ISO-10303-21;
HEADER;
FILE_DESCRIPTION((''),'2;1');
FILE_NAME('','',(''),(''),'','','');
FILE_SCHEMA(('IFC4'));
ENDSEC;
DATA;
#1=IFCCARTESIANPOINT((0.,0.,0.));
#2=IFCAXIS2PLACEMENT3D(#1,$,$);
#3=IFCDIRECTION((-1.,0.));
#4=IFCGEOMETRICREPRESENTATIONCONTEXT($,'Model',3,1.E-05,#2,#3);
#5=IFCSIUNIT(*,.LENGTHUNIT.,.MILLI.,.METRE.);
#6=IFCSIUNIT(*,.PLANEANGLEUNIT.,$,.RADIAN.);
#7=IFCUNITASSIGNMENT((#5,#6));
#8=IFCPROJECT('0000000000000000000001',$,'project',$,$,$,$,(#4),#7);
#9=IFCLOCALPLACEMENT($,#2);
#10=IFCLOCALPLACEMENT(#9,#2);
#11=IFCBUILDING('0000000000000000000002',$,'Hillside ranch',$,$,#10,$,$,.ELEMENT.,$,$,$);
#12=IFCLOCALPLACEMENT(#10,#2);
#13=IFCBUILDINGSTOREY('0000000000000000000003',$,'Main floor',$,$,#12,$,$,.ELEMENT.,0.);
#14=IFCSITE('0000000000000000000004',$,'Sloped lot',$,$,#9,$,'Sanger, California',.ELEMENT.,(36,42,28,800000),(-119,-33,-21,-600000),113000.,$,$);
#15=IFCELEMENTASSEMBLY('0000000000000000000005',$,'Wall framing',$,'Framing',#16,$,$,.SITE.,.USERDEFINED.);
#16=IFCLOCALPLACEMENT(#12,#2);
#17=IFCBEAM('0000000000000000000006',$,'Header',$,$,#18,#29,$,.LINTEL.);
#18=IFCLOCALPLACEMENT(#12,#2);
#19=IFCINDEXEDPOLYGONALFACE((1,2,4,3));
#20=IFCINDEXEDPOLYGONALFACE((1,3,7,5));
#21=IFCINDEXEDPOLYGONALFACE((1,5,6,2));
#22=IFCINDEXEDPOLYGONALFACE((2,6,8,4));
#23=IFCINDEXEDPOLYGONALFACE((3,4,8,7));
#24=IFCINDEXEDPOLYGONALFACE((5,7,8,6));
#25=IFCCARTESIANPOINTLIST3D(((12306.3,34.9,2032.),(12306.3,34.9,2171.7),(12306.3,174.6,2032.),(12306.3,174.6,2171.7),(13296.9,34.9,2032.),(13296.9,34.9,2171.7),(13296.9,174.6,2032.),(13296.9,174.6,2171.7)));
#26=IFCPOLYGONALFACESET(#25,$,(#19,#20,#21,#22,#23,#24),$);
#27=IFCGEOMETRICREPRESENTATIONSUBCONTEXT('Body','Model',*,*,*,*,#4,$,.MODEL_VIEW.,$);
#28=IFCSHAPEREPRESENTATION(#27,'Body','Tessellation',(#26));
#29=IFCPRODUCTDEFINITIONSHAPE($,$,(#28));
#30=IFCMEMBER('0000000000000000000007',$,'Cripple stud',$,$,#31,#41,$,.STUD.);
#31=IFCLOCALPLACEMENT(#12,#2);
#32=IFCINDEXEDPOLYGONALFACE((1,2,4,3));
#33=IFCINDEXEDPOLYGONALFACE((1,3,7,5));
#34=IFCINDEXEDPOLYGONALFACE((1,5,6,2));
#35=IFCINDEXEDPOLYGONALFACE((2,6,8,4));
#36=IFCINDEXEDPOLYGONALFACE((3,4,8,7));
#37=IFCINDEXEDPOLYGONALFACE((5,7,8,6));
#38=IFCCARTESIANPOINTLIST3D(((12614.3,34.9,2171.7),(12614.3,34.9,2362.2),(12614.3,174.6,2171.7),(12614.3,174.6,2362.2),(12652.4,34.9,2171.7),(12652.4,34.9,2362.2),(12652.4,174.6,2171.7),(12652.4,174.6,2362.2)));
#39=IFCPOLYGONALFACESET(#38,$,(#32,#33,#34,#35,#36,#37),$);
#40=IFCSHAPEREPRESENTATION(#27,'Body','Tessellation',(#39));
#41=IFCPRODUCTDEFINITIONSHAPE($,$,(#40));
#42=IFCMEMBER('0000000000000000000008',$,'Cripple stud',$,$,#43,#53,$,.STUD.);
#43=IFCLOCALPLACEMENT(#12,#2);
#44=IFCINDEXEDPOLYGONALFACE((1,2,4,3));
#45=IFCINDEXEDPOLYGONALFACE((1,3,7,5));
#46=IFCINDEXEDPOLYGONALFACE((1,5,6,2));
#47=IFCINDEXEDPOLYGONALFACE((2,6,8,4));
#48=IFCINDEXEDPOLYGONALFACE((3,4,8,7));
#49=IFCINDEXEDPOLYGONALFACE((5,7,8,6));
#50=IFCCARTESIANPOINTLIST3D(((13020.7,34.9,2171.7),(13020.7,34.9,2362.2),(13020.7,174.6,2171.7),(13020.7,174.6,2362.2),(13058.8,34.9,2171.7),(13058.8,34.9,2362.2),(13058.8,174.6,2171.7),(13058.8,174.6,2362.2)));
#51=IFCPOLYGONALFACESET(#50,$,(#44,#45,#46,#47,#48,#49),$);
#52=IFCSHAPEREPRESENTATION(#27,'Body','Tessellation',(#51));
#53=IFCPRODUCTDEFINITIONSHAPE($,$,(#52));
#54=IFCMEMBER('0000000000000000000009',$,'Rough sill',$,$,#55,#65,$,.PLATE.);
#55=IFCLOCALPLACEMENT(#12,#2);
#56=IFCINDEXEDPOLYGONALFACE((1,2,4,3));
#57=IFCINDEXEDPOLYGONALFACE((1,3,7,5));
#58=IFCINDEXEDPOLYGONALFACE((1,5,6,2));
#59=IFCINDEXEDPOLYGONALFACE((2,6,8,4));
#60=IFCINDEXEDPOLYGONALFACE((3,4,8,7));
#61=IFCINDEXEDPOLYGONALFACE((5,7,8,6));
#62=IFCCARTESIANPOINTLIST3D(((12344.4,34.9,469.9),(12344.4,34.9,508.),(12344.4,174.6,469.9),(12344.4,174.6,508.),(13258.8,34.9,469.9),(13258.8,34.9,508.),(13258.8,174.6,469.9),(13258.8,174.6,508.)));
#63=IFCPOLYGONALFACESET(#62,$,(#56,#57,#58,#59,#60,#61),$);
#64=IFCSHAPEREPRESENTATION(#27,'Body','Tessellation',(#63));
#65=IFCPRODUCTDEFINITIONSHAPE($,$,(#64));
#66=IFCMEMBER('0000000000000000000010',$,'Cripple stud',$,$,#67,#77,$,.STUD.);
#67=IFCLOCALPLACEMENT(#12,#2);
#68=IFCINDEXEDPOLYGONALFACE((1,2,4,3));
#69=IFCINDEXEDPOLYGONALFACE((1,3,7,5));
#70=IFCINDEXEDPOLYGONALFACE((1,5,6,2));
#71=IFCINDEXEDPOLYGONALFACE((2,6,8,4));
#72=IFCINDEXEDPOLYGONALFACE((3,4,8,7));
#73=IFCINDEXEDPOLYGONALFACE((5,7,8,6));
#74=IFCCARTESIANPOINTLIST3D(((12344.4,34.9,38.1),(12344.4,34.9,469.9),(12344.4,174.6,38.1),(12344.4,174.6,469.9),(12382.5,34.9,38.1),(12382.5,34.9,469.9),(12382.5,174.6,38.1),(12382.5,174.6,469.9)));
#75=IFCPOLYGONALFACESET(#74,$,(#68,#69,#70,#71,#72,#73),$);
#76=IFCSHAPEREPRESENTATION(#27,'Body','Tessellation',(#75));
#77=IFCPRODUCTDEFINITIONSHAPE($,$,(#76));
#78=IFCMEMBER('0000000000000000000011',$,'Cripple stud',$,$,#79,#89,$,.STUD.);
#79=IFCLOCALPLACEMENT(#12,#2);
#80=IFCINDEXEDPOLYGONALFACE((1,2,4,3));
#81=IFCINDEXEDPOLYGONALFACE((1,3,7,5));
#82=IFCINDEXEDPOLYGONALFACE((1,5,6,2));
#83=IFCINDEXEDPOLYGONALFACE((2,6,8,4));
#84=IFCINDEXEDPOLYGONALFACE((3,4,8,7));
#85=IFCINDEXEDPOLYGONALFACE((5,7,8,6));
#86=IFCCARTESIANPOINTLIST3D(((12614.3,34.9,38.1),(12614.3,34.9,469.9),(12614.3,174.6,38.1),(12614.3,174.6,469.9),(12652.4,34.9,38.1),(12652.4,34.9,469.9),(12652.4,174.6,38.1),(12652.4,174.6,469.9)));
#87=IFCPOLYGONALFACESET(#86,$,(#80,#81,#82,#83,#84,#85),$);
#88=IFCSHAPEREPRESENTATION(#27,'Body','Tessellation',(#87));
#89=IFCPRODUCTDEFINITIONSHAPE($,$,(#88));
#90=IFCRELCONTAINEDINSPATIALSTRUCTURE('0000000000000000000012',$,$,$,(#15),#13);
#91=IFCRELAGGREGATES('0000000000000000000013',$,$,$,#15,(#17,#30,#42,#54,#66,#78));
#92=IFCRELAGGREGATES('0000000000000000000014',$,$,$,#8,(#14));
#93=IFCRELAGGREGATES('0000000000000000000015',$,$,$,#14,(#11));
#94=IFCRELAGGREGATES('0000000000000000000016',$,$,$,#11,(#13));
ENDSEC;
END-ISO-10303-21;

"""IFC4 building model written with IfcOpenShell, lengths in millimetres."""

from ifc_helpers import new_model, si_unit, direction, frame, origin, origin_with_axes, place, context, subcontext, project, spatial, polyline, outline, extrude, element, aggregate, save


model = new_model("IFC4")

# Units and contexts
model_context = context("Model", 3, precision=1e-05, world=origin(), true_north=direction((-1.0, 0.0)))
body_context = subcontext(model_context, "Body", "Model", "MODEL_VIEW")
ifc_project = project(units=[si_unit("LENGTHUNIT", "METRE", prefix="MILLI"), si_unit("PLANEANGLEUNIT", "RADIAN")], contexts=[model_context])

# Site, building, storey
site_placement = place(None, origin())
site = spatial("IfcSite", under=ifc_project, at=site_placement, Name="Sloped lot", LongName="Sanger, California", CompositionType="ELEMENT", RefLatitude=(36, 42, 28, 800000), RefLongitude=(-119, -33, -21, -600000), RefElevation=113000.0)
building_placement = place(site_placement, origin())
building = spatial("IfcBuilding", under=site, at=building_placement, Name="Hillside ranch", CompositionType="ELEMENT")
storey_placement = place(building_placement, origin())
storey = spatial("IfcBuildingStorey", under=building, at=storey_placement, Name="Main floor", CompositionType="ELEMENT", Elevation=0.0)

# Element assembly, beam, members
assembly_placement = place(storey_placement, origin_with_axes())
assembly = element("IfcElementAssembly", 1, at=assembly_placement, inside=storey, Name="Wall framing", ObjectType="Framing", AssemblyPlace="SITE", PredefinedType="USERDEFINED")
beam_1_placement = place(storey_placement, origin_with_axes())
beam_1 = element("IfcBeam", 2, at=beam_1_placement, Name="Header", PredefinedType="LINTEL", context=body_context, shape_type="SweptSolid", body=[
    extrude(outline(polyline([(0.0, 0.0), (990.6, 0.0), (990.6, 139.7), (0.0, 139.7), (0.0, 0.0)])), frame((12306.3, 34.9, 2032.0), z_axis=(0.0, 0.0, 1.0), x_axis=(1.0, 0.0, 0.0)), (0.0, 0.0, 1.0), 139.7),
])
member_1_placement = place(storey_placement, origin_with_axes())
member_1 = element("IfcMember", 3, at=member_1_placement, Name="Cripple stud", PredefinedType="STUD", context=body_context, shape_type="SweptSolid", body=[
    extrude(outline(polyline([(0.0, 0.0), (38.1, 0.0), (38.1, 139.7), (0.0, 139.7), (0.0, 0.0)])), frame((12614.3, 34.9, 2171.7), z_axis=(0.0, 0.0, 1.0), x_axis=(1.0, 0.0, 0.0)), (0.0, 0.0, 1.0), 190.5),
])
member_2_placement = place(storey_placement, origin_with_axes())
member_2 = element("IfcMember", 4, at=member_2_placement, Name="Cripple stud", PredefinedType="STUD", context=body_context, shape_type="SweptSolid", body=[
    extrude(outline(polyline([(0.0, 0.0), (38.1, 0.0), (38.1, 139.7), (0.0, 139.7), (0.0, 0.0)])), frame((13020.7, 34.9, 2171.7), z_axis=(0.0, 0.0, 1.0), x_axis=(1.0, 0.0, 0.0)), (0.0, 0.0, 1.0), 190.5),
])
member_3_placement = place(storey_placement, origin_with_axes())
member_3 = element("IfcMember", 5, at=member_3_placement, Name="Rough sill", PredefinedType="PLATE", context=body_context, shape_type="SweptSolid", body=[
    extrude(outline(polyline([(0.0, 0.0), (914.4, 0.0), (914.4, 139.7), (0.0, 139.7), (0.0, 0.0)])), frame((12344.4, 34.9, 469.9), z_axis=(0.0, 0.0, 1.0), x_axis=(1.0, 0.0, 0.0)), (0.0, 0.0, 1.0), 38.1),
])
member_4_placement = place(storey_placement, origin_with_axes())
member_4 = element("IfcMember", 6, at=member_4_placement, Name="Cripple stud", PredefinedType="STUD", context=body_context, shape_type="SweptSolid", body=[
    extrude(outline(polyline([(0.0, 0.0), (38.1, 0.0), (38.1, 139.7), (0.0, 139.7), (0.0, 0.0)])), frame((12344.4, 34.9, 38.1), z_axis=(0.0, 0.0, 1.0), x_axis=(1.0, 0.0, 0.0)), (0.0, 0.0, 1.0), 431.8),
])
member_5_placement = place(storey_placement, origin_with_axes())
member_5 = element("IfcMember", 7, at=member_5_placement, Name="Cripple stud", PredefinedType="STUD", context=body_context, shape_type="SweptSolid", body=[
    extrude(outline(polyline([(0.0, 0.0), (38.1, 0.0), (38.1, 139.7), (0.0, 139.7), (0.0, 0.0)])), frame((12614.3, 34.9, 38.1), z_axis=(0.0, 0.0, 1.0), x_axis=(1.0, 0.0, 0.0)), (0.0, 0.0, 1.0), 431.8),
])
aggregate(assembly, [beam_1, member_1, member_2, member_3, member_4, member_5])

save(model, "model.ifc")
